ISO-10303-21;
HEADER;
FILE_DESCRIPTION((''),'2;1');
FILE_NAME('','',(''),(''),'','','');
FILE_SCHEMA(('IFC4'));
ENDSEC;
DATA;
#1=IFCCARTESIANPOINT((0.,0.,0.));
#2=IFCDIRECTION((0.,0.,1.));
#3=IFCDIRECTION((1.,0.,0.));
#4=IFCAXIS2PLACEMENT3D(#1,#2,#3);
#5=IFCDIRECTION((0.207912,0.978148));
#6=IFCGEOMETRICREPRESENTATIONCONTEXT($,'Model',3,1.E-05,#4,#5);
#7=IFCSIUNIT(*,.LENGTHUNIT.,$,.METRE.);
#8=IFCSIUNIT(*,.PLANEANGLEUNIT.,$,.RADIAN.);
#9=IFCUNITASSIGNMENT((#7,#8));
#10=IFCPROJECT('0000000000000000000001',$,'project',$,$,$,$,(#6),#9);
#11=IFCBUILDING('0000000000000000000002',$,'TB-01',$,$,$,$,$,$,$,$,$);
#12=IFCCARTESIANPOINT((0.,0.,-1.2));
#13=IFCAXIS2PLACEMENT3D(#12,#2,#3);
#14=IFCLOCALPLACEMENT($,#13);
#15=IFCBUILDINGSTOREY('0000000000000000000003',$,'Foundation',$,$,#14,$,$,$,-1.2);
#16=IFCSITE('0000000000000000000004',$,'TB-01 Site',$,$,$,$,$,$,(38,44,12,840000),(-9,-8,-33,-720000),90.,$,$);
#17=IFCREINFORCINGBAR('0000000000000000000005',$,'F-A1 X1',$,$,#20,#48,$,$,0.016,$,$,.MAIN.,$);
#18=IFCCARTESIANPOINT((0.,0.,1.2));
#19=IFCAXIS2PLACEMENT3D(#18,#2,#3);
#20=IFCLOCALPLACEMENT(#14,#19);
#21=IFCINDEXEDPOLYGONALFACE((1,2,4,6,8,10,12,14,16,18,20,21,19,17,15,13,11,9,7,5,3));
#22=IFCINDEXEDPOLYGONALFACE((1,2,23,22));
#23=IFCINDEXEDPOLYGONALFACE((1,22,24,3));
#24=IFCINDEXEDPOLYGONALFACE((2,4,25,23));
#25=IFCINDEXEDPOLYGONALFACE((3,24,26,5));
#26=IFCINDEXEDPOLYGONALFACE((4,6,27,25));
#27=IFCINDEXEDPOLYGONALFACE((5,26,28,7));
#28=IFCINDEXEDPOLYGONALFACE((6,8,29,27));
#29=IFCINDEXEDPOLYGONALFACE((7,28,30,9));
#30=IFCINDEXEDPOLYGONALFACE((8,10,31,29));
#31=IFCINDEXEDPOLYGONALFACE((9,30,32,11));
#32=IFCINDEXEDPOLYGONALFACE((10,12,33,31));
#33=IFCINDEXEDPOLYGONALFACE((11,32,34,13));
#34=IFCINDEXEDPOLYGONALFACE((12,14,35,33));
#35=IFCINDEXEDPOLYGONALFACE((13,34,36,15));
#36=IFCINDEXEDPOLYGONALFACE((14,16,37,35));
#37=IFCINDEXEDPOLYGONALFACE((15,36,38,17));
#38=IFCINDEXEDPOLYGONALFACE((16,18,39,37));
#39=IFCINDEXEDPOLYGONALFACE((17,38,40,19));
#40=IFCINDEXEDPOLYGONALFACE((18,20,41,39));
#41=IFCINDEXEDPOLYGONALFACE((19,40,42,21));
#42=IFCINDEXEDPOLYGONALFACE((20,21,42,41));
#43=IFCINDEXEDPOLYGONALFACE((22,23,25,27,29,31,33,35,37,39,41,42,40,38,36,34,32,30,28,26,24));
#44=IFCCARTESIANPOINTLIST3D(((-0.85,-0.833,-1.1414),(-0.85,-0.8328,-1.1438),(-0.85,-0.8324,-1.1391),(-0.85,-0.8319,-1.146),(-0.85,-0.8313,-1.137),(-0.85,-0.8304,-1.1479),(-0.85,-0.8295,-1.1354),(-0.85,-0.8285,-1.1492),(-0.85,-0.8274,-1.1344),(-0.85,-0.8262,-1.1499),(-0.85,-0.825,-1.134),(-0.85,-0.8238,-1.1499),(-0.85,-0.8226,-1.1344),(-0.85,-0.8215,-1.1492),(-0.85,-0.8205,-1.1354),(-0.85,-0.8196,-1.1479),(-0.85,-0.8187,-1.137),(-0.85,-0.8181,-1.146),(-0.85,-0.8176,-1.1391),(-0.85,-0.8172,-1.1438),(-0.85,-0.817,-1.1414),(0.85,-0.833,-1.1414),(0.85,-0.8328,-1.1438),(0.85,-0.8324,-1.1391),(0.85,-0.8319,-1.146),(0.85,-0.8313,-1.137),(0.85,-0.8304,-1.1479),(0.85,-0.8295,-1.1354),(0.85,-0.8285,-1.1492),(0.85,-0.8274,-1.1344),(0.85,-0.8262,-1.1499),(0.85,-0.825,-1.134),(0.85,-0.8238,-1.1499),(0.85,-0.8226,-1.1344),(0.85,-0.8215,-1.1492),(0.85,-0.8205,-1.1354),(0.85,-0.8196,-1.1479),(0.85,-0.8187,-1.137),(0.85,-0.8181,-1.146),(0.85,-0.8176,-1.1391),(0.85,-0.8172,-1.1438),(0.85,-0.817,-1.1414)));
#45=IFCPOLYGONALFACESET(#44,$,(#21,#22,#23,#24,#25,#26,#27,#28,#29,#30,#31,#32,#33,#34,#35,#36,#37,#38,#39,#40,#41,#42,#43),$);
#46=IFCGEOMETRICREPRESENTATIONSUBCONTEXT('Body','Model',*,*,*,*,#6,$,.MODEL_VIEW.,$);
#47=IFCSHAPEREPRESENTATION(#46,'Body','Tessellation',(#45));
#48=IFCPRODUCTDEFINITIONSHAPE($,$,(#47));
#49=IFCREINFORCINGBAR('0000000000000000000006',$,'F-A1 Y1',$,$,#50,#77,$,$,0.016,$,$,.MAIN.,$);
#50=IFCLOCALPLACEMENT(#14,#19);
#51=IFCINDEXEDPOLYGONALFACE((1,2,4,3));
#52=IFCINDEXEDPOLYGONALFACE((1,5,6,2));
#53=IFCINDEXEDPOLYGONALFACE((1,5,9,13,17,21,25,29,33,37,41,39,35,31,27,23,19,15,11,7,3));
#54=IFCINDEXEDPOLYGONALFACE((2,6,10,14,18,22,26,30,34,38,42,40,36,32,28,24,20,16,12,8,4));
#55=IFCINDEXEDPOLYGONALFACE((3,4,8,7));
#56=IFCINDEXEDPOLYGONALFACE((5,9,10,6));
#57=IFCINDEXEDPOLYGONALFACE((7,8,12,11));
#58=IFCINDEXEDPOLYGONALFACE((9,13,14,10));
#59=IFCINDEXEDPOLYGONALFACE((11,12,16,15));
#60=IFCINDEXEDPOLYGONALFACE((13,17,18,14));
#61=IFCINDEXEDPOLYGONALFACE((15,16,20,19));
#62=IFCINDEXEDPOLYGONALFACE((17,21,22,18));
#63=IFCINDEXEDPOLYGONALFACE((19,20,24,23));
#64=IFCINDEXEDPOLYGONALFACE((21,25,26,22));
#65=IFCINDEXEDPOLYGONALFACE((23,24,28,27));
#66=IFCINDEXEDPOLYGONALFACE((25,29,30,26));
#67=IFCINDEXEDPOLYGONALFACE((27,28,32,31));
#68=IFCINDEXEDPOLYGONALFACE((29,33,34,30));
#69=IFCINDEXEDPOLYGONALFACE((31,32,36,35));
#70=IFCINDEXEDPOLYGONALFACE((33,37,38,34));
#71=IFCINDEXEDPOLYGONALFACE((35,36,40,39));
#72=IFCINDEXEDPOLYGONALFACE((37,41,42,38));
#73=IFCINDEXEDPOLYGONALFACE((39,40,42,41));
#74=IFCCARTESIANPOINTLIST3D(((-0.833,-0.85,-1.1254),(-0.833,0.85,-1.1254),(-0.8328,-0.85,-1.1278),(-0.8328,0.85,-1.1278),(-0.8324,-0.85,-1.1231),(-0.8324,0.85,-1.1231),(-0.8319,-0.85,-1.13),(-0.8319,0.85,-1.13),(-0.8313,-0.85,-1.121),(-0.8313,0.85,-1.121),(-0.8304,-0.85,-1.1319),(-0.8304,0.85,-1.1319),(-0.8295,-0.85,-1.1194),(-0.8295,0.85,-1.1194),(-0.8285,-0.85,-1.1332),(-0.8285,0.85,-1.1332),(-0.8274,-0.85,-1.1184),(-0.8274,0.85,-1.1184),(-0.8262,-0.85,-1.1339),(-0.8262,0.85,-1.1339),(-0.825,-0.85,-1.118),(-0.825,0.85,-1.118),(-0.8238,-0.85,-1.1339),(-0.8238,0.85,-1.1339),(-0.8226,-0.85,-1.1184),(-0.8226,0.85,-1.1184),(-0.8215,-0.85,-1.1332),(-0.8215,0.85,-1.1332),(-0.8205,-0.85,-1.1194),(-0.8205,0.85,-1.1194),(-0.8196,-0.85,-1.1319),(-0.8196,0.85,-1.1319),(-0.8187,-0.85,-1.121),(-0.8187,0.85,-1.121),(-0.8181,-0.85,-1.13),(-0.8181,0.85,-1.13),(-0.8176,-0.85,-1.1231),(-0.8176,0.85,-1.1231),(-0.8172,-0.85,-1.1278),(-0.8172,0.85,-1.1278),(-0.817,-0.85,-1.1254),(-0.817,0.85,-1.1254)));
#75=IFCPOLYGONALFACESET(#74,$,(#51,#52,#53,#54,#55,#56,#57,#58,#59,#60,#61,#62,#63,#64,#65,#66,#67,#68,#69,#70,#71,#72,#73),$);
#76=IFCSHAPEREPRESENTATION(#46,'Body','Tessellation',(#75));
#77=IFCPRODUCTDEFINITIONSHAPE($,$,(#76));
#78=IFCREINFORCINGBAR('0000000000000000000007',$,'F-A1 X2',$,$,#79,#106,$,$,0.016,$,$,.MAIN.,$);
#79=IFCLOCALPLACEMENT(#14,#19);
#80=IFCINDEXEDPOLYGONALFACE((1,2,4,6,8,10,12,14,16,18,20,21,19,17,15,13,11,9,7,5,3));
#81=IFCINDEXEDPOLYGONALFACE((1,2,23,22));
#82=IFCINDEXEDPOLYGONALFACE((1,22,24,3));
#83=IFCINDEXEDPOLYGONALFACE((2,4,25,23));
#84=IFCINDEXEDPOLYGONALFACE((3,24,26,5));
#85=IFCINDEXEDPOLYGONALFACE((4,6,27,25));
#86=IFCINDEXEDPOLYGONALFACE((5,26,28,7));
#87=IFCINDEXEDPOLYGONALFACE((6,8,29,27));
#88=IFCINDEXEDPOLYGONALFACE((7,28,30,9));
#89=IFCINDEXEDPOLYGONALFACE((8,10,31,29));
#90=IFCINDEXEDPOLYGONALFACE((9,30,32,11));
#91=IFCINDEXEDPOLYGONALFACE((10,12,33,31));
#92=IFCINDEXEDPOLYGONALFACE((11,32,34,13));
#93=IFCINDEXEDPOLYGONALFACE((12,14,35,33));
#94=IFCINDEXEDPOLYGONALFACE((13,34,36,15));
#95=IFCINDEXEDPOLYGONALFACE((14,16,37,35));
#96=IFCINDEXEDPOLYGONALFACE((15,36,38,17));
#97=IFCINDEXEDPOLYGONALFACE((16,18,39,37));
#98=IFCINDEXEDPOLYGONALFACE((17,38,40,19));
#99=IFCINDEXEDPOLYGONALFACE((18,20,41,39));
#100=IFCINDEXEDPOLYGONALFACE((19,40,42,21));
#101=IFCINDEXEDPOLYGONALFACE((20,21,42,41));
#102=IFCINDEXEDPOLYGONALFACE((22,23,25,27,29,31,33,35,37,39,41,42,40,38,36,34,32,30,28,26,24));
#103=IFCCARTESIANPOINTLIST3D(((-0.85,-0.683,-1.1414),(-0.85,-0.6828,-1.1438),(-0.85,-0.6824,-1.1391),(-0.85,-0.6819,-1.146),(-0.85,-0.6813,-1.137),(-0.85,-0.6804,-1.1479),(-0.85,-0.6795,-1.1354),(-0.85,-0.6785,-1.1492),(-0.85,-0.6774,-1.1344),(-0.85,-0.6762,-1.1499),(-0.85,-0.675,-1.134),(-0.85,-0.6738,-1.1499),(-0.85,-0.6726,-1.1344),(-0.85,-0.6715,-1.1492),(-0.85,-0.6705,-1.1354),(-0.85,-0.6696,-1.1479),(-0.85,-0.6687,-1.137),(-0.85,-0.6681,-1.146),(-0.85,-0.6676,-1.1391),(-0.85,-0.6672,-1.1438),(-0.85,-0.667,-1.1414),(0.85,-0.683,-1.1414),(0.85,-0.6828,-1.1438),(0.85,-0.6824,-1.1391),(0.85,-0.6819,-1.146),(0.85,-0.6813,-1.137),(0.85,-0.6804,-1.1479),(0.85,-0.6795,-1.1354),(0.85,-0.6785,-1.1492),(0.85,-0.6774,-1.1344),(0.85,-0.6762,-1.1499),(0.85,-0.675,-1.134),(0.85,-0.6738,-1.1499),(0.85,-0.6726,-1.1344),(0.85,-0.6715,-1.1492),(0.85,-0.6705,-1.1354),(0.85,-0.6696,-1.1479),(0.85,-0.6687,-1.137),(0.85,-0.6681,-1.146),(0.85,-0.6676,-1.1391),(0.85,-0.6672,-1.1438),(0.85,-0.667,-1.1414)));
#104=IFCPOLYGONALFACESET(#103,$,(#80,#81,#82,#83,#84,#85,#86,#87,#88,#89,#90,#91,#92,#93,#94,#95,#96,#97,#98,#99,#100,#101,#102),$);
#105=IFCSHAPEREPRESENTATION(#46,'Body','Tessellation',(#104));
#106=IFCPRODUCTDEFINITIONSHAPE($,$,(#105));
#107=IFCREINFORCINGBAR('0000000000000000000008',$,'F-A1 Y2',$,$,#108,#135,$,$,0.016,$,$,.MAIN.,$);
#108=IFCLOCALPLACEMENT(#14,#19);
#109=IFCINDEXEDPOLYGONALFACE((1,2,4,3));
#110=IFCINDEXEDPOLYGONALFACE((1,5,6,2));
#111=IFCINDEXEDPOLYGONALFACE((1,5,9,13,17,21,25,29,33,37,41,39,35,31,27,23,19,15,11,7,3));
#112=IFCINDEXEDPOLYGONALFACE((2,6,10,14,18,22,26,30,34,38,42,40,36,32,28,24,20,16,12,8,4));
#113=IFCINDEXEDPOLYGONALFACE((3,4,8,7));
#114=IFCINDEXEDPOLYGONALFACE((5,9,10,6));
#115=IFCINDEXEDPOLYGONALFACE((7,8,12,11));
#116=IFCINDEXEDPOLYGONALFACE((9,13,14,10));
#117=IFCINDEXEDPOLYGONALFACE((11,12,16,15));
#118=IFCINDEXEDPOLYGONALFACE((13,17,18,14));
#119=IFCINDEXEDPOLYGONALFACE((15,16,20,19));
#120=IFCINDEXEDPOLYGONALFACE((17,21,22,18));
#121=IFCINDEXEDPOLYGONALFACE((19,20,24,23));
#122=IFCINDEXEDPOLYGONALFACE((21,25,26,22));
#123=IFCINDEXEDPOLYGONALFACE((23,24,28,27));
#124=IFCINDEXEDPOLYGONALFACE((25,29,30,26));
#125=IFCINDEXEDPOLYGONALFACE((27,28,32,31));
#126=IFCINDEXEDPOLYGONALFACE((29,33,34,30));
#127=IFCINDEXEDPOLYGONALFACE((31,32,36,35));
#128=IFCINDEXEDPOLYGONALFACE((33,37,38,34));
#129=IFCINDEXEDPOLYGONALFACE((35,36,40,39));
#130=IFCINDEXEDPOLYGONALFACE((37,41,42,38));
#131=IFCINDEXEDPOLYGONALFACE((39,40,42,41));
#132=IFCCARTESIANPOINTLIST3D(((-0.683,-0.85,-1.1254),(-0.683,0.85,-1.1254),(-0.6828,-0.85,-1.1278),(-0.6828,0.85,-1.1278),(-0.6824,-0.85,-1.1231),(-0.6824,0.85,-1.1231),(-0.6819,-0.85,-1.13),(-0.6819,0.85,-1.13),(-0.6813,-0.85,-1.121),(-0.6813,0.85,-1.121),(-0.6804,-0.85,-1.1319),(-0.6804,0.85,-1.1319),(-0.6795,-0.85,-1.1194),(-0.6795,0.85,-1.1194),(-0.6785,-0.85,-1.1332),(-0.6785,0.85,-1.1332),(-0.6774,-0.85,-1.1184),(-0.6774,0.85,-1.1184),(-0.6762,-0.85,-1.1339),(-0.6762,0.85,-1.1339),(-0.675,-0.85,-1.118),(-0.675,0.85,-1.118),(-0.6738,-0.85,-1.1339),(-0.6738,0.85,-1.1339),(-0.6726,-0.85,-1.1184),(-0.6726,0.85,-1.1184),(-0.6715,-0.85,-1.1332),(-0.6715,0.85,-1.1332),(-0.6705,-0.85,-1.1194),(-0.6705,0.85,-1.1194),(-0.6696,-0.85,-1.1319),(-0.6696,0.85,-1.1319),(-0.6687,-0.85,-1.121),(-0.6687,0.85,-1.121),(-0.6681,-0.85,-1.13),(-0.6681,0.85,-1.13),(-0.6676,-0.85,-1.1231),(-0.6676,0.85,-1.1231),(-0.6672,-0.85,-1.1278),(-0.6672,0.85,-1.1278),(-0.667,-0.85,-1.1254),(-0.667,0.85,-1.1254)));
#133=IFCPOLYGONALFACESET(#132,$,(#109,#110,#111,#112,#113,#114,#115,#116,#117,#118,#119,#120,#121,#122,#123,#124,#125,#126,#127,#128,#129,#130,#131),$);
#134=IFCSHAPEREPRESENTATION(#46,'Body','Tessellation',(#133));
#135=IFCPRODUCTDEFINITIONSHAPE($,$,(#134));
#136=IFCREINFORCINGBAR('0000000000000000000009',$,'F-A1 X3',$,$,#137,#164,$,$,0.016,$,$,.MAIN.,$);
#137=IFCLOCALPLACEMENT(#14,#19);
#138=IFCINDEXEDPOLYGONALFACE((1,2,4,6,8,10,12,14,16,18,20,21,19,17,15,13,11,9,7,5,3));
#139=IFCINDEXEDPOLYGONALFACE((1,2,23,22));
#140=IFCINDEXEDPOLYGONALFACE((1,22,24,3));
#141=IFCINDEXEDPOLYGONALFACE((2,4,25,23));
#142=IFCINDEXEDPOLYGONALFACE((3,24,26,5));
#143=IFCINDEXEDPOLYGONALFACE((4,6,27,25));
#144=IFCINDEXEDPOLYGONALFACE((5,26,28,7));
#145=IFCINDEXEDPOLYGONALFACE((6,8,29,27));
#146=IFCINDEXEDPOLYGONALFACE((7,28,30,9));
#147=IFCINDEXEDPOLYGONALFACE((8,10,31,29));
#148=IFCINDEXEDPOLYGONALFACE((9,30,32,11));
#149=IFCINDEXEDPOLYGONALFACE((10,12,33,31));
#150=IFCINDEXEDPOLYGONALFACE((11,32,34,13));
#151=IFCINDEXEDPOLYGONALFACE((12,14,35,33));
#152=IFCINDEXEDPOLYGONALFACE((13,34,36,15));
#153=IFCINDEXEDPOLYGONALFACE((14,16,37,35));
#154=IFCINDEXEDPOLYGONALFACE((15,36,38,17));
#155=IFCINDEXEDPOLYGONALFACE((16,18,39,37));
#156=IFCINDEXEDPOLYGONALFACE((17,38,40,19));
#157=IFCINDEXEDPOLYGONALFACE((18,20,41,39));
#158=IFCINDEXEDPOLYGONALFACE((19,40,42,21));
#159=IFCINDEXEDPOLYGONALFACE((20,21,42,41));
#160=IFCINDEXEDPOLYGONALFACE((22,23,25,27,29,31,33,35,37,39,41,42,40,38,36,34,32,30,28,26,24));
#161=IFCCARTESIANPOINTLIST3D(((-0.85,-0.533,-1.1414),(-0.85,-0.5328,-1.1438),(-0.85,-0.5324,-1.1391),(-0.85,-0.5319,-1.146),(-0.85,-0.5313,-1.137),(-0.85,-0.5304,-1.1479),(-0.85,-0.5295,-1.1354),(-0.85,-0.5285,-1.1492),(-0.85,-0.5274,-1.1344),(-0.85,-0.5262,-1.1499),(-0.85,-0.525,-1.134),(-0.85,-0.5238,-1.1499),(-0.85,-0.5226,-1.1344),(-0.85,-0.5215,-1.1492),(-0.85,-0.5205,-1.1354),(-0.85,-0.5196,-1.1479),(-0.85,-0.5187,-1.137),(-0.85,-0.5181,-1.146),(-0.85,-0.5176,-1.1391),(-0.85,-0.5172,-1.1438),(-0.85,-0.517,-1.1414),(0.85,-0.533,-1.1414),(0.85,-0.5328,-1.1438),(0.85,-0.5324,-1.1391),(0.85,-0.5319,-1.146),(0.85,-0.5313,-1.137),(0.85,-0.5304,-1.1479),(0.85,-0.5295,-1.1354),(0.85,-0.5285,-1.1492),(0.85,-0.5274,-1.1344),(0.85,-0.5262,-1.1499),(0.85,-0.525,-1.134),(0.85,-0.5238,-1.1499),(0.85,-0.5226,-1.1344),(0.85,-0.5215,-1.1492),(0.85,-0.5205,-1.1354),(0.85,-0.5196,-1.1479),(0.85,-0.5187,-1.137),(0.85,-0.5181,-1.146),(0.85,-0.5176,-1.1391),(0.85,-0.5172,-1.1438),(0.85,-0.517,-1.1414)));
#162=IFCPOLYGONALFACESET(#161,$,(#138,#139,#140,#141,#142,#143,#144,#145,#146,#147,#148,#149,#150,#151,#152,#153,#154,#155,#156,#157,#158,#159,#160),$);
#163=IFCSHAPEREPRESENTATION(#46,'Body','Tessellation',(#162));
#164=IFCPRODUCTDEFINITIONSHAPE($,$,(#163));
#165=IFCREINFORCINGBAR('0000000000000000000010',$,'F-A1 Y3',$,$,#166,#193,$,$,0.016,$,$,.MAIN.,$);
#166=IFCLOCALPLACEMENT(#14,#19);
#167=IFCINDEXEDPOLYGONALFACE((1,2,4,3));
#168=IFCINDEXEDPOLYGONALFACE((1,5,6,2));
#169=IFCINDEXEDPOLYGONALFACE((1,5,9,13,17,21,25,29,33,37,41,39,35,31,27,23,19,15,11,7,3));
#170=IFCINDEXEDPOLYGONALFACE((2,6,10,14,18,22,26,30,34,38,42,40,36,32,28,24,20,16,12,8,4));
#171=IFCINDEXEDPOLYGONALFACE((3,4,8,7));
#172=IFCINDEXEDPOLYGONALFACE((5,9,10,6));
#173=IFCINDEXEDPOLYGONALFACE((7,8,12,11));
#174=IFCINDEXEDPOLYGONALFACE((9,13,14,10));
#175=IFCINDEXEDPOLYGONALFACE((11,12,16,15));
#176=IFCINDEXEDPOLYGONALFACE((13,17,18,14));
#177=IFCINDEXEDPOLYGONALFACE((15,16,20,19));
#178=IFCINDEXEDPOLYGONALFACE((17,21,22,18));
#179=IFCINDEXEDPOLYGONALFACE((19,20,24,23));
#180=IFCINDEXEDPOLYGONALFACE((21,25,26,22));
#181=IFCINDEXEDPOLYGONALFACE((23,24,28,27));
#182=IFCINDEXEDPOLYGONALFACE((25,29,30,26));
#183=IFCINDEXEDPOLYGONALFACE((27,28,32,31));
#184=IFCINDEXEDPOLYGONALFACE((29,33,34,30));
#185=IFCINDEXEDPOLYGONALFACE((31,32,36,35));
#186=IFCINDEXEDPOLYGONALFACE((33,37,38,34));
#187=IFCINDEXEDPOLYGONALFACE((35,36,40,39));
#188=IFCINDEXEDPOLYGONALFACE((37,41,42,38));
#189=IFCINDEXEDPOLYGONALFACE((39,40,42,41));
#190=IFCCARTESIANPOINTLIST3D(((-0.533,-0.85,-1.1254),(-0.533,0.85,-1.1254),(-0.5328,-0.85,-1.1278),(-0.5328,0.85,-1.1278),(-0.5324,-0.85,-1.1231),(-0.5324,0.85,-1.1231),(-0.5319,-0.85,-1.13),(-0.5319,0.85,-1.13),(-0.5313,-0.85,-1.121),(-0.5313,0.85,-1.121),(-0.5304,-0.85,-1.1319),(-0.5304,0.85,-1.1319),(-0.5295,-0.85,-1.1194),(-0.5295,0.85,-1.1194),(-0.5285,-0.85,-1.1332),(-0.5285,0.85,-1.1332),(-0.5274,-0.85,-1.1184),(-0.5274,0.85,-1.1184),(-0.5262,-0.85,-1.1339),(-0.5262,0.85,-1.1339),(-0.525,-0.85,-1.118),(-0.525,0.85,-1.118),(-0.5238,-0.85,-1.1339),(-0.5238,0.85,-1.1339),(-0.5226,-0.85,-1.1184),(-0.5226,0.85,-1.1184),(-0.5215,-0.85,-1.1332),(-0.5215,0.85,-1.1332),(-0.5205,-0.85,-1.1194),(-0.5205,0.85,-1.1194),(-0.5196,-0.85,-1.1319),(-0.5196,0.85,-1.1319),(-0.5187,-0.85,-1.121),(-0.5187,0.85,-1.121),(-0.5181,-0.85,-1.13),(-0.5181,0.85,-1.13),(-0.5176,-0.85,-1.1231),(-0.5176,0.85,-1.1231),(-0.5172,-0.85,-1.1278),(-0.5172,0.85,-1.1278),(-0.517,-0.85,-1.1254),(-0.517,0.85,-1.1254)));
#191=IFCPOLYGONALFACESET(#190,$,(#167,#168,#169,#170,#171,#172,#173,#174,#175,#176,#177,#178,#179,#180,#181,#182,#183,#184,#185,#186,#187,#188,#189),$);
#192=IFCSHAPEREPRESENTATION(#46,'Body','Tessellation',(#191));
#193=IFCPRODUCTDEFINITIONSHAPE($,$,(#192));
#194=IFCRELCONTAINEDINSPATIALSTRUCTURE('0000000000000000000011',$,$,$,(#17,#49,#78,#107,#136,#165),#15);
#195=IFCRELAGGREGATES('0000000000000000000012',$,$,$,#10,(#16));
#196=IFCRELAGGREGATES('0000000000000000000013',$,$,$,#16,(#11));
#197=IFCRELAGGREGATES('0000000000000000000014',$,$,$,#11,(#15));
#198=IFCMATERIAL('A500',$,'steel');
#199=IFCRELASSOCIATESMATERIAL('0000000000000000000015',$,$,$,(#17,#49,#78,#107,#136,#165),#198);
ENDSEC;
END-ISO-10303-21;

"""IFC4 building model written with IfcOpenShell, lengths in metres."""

from ifc_helpers import new_model, entity, si_unit, direction, frame, origin_with_axes, place, context, subcontext, project, spatial, material, element, save


model = new_model("IFC4")

# Units and contexts
model_context = context("Model", 3, precision=1e-05, world=origin_with_axes(), true_north=direction((0.207912, 0.978148)))
body_context = subcontext(model_context, "Body", "Model", "MODEL_VIEW")
ifc_project = project(units=[si_unit("LENGTHUNIT", "METRE"), si_unit("PLANEANGLEUNIT", "RADIAN")], contexts=[model_context])

# Site, building, storey
site = spatial("IfcSite", under=ifc_project, Name="TB-01 Site", RefLatitude=(38, 44, 12, 840000), RefLongitude=(-9, -8, -33, -720000), RefElevation=90.0)
building = spatial("IfcBuilding", under=site, Name="TB-01")
storey_placement = place(None, frame((0.0, 0.0, -1.2), z_axis=(0.0, 0.0, 1.0), x_axis=(1.0, 0.0, 0.0)))
storey = spatial("IfcBuildingStorey", under=building, at=storey_placement, Name="Foundation", Elevation=-1.2)

# Reinforcing bars
ifc_material_1 = material(Name="A500", Category="steel")
reinforcing_bar_1_placement = place(storey_placement, frame((0.0, 0.0, 1.2), z_axis=(0.0, 0.0, 1.0), x_axis=(1.0, 0.0, 0.0)))
element("IfcReinforcingBar", 1, at=reinforcing_bar_1_placement, inside=storey, material=ifc_material_1, Name="F-A1 X1", NominalDiameter=0.016, PredefinedType="MAIN", context=body_context, shape_type="AdvancedSweptSolid", body=[
    entity("IfcSweptDiskSolid", entity("IfcPolyline", [entity("IfcCartesianPoint", [-0.85, -0.825, -1.142]), entity("IfcCartesianPoint", [0.85, -0.825, -1.142])]), 0.008),
])
reinforcing_bar_2_placement = place(storey_placement, frame((0.0, 0.0, 1.2), z_axis=(0.0, 0.0, 1.0), x_axis=(1.0, 0.0, 0.0)))
element("IfcReinforcingBar", 2, at=reinforcing_bar_2_placement, inside=storey, material=ifc_material_1, Name="F-A1 Y1", NominalDiameter=0.016, PredefinedType="MAIN", context=body_context, shape_type="AdvancedSweptSolid", body=[
    entity("IfcSweptDiskSolid", entity("IfcPolyline", [entity("IfcCartesianPoint", [-0.825, -0.85, -1.126]), entity("IfcCartesianPoint", [-0.825, 0.85, -1.126])]), 0.008),
])
reinforcing_bar_3_placement = place(storey_placement, frame((0.0, 0.0, 1.2), z_axis=(0.0, 0.0, 1.0), x_axis=(1.0, 0.0, 0.0)))
element("IfcReinforcingBar", 3, at=reinforcing_bar_3_placement, inside=storey, material=ifc_material_1, Name="F-A1 X2", NominalDiameter=0.016, PredefinedType="MAIN", context=body_context, shape_type="AdvancedSweptSolid", body=[
    entity("IfcSweptDiskSolid", entity("IfcPolyline", [entity("IfcCartesianPoint", [-0.85, -0.675, -1.142]), entity("IfcCartesianPoint", [0.85, -0.675, -1.142])]), 0.008),
])
reinforcing_bar_4_placement = place(storey_placement, frame((0.0, 0.0, 1.2), z_axis=(0.0, 0.0, 1.0), x_axis=(1.0, 0.0, 0.0)))
element("IfcReinforcingBar", 4, at=reinforcing_bar_4_placement, inside=storey, material=ifc_material_1, Name="F-A1 Y2", NominalDiameter=0.016, PredefinedType="MAIN", context=body_context, shape_type="AdvancedSweptSolid", body=[
    entity("IfcSweptDiskSolid", entity("IfcPolyline", [entity("IfcCartesianPoint", [-0.675, -0.85, -1.126]), entity("IfcCartesianPoint", [-0.675, 0.85, -1.126])]), 0.008),
])
reinforcing_bar_5_placement = place(storey_placement, frame((0.0, 0.0, 1.2), z_axis=(0.0, 0.0, 1.0), x_axis=(1.0, 0.0, 0.0)))
element("IfcReinforcingBar", 5, at=reinforcing_bar_5_placement, inside=storey, material=ifc_material_1, Name="F-A1 X3", NominalDiameter=0.016, PredefinedType="MAIN", context=body_context, shape_type="AdvancedSweptSolid", body=[
    entity("IfcSweptDiskSolid", entity("IfcPolyline", [entity("IfcCartesianPoint", [-0.85, -0.525, -1.142]), entity("IfcCartesianPoint", [0.85, -0.525, -1.142])]), 0.008),
])
reinforcing_bar_6_placement = place(storey_placement, frame((0.0, 0.0, 1.2), z_axis=(0.0, 0.0, 1.0), x_axis=(1.0, 0.0, 0.0)))
element("IfcReinforcingBar", 6, at=reinforcing_bar_6_placement, inside=storey, material=ifc_material_1, Name="F-A1 Y3", NominalDiameter=0.016, PredefinedType="MAIN", context=body_context, shape_type="AdvancedSweptSolid", body=[
    entity("IfcSweptDiskSolid", entity("IfcPolyline", [entity("IfcCartesianPoint", [-0.525, -0.85, -1.126]), entity("IfcCartesianPoint", [-0.525, 0.85, -1.126])]), 0.008),
])

save(model, "model.ifc")
